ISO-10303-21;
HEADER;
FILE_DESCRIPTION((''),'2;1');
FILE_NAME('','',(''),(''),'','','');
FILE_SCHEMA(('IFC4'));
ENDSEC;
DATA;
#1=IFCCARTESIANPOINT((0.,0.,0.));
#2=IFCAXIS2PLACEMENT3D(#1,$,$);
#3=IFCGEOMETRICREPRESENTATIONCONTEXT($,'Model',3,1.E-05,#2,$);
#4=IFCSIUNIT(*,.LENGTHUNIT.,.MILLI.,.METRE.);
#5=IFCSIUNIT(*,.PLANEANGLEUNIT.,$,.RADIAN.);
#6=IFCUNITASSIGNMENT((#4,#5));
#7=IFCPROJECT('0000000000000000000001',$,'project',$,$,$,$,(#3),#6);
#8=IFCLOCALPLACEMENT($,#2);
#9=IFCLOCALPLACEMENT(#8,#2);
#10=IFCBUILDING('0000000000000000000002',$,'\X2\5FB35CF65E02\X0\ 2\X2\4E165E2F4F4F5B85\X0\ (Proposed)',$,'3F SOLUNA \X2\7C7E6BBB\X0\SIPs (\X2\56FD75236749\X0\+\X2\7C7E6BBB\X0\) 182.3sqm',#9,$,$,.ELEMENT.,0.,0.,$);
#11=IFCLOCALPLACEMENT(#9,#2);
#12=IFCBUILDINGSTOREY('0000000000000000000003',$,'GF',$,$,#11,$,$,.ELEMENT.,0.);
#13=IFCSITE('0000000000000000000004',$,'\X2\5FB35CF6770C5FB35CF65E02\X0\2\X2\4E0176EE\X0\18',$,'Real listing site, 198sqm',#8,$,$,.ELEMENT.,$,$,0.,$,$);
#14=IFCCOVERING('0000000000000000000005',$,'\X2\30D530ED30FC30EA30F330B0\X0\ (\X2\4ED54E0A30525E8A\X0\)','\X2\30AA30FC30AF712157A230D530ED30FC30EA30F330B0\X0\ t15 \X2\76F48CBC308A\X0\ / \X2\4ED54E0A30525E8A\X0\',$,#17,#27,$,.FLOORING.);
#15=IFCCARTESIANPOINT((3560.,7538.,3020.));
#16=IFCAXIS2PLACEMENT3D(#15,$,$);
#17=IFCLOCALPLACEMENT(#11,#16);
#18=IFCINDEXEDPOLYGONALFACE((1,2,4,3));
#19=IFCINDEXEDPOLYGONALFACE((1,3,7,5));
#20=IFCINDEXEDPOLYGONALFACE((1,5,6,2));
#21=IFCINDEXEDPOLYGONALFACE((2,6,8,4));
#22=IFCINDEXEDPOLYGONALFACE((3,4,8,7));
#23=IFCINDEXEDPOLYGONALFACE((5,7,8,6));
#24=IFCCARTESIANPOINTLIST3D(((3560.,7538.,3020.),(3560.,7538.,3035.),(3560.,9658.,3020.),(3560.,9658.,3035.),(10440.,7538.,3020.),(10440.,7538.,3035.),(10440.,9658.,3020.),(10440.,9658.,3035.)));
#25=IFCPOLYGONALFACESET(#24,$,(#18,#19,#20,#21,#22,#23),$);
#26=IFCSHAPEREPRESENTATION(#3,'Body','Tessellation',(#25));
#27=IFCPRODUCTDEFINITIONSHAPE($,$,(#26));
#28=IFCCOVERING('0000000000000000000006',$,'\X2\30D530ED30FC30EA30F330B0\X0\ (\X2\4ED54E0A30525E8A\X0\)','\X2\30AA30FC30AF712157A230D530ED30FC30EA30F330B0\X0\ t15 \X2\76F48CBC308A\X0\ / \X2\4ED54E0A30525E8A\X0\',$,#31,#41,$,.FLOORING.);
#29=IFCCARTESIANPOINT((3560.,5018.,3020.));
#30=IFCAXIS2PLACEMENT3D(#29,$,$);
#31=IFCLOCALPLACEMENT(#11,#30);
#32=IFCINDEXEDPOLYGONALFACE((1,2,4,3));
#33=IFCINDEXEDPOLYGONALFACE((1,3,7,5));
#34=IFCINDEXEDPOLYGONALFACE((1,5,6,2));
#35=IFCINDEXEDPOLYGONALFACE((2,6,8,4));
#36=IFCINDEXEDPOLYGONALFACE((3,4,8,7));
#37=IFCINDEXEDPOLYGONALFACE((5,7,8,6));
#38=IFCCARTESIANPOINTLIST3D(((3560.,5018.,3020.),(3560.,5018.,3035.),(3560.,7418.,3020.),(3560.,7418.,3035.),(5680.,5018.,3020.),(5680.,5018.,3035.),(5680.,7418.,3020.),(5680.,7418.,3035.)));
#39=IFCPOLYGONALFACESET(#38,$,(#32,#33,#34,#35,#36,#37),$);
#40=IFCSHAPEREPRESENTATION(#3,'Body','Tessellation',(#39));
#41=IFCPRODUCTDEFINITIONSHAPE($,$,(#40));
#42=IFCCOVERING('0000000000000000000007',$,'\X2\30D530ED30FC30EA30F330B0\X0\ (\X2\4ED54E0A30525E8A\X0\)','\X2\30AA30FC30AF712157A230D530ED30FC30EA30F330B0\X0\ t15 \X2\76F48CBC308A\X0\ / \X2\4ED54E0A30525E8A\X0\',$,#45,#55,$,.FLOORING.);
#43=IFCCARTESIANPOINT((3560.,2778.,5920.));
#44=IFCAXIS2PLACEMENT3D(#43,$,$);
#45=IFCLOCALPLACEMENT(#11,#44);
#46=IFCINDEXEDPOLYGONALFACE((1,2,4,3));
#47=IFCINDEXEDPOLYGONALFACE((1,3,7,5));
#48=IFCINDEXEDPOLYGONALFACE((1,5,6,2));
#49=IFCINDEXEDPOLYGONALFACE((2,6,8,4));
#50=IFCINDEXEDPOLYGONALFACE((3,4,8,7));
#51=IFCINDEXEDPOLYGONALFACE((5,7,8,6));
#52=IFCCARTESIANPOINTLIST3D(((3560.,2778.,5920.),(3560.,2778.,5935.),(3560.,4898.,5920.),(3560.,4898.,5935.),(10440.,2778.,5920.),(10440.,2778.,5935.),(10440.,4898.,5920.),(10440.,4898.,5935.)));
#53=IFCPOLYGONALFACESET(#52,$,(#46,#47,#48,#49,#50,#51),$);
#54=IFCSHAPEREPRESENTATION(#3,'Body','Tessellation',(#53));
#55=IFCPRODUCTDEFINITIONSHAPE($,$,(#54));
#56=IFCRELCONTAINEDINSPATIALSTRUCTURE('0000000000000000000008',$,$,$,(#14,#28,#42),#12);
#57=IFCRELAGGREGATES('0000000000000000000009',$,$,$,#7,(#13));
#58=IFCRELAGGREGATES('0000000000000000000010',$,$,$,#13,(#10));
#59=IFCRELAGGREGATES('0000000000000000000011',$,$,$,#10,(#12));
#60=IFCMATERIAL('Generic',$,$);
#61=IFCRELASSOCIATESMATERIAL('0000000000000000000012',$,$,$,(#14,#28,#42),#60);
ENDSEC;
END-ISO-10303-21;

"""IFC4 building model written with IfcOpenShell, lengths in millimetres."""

from ifc_helpers import new_model, si_unit, frame, frame_2d, origin, place, context, project, spatial, rectangle, extrude, material, element, save


model = new_model("IFC4")

# Units and contexts
model_context = context("Model", 3, precision=1e-05, world=origin())
ifc_project = project(units=[si_unit("LENGTHUNIT", "METRE", prefix="MILLI"), si_unit("PLANEANGLEUNIT", "RADIAN")], contexts=[model_context])

# Site, building, storey
site_placement = place(None, origin())
site = spatial("IfcSite", under=ifc_project, at=site_placement, Name="徳島県徳島市2丁目18", ObjectType="Real listing site, 198sqm", CompositionType="ELEMENT", RefElevation=0.0)
building_placement = place(site_placement, origin())
building = spatial("IfcBuilding", under=site, at=building_placement, Name="徳島市 2世帯住宅 (Proposed)", ObjectType="3F SOLUNA 籾殻SIPs (国産杉+籾殻) 182.3sqm", CompositionType="ELEMENT", ElevationOfRefHeight=0.0, ElevationOfTerrain=0.0)
storey_placement = place(building_placement, origin())
storey = spatial("IfcBuildingStorey", under=building, at=storey_placement, Name="GF", CompositionType="ELEMENT", Elevation=0.0)

# Shared definitions
ifc_material_1 = material(Name="Generic")

# Coverings
covering_1_placement = place(storey_placement, frame((3560.0, 7538.0, 3020.0)))
element("IfcCovering", 1, at=covering_1_placement, inside=storey, material=ifc_material_1, Name="フローリング (仕上げ床)", Description="オーク無垢フローリング t15 直貼り / 仕上げ床", PredefinedType="FLOORING", context=model_context, shape_type="SweptSolid", body=[
    extrude(rectangle(XDim=6880.0, YDim=2120.0, at=frame_2d((3440.0, 1060.0))), frame((3560.0, 7538.0, 3020.0)), (0.0, 0.0, 1.0), 15.0),
])
covering_2_placement = place(storey_placement, frame((3560.0, 5018.0, 3020.0)))
element("IfcCovering", 2, at=covering_2_placement, inside=storey, material=ifc_material_1, Name="フローリング (仕上げ床)", Description="オーク無垢フローリング t15 直貼り / 仕上げ床", PredefinedType="FLOORING", context=model_context, shape_type="SweptSolid", body=[
    extrude(rectangle(XDim=2120.0, YDim=2400.0, at=frame_2d((1060.0, 1200.0))), frame((3560.0, 5018.0, 3020.0)), (0.0, 0.0, 1.0), 15.0),
])
covering_3_placement = place(storey_placement, frame((3560.0, 2778.0, 5920.0)))
element("IfcCovering", 3, at=covering_3_placement, inside=storey, material=ifc_material_1, Name="フローリング (仕上げ床)", Description="オーク無垢フローリング t15 直貼り / 仕上げ床", PredefinedType="FLOORING", context=model_context, shape_type="SweptSolid", body=[
    extrude(rectangle(XDim=6880.0, YDim=2120.0, at=frame_2d((3440.0, 1060.0))), frame((3560.0, 2778.0, 5920.0)), (0.0, 0.0, 1.0), 15.0),
])

save(model, "model.ifc")
